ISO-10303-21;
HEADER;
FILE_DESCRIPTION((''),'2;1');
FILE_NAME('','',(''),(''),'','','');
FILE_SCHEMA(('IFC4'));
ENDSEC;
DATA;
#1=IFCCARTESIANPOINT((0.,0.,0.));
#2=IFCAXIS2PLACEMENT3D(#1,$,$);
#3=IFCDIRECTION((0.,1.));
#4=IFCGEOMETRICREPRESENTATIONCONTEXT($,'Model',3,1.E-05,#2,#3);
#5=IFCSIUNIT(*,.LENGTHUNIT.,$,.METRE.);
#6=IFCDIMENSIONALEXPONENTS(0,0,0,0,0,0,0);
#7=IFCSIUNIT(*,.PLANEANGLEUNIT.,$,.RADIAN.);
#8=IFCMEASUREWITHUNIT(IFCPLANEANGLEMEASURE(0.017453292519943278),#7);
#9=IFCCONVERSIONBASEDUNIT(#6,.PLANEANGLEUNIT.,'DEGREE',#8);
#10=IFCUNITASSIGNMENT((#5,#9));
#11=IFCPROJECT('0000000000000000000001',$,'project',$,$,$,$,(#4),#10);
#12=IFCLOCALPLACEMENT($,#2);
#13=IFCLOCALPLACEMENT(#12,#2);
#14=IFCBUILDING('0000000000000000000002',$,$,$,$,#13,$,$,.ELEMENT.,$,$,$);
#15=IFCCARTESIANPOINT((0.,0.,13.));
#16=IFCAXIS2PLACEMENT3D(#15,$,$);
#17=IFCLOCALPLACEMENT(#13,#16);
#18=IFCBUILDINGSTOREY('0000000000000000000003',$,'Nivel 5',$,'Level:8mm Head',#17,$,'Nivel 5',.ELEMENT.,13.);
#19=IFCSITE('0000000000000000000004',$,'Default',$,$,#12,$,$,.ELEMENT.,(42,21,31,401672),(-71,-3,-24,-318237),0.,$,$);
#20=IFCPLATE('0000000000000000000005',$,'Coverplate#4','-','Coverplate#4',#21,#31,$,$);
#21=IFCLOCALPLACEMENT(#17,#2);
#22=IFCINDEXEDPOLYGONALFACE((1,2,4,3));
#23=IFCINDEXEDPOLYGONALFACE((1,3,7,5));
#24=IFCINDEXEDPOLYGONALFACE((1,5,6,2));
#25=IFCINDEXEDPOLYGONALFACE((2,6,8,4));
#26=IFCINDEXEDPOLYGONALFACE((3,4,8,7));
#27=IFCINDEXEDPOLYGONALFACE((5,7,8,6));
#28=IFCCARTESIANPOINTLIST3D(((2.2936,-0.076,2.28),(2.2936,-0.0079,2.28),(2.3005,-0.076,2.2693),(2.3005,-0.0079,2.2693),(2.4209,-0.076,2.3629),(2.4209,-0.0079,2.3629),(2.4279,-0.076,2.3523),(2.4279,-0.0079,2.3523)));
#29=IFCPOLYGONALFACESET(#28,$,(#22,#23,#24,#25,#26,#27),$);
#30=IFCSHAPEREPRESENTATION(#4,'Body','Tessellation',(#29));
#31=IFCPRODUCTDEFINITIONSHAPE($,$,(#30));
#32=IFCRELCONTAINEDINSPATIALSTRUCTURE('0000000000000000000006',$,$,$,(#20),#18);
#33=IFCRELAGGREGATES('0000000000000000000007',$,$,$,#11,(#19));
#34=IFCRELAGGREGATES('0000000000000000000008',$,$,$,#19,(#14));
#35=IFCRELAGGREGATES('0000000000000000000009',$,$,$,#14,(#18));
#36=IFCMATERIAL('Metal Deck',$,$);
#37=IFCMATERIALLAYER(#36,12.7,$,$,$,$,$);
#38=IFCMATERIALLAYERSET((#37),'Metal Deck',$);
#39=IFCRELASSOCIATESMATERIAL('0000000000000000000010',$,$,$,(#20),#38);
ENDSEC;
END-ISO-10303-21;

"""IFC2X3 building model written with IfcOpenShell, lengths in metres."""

from ifc_helpers import new_model, entity, si_unit, converted_unit, direction, frame, origin, origin_with_axes, place, context, project, spatial, polyline, outline, extrude, material, layer, layer_set, element, save


model = new_model("IFC2X3")

# Units and contexts
model_context = context("Model", 3, precision=1e-05, world=origin(), true_north=direction((0.0, 1.0)))
ifc_project = project(units=[si_unit("LENGTHUNIT", "METRE"), converted_unit("PLANEANGLEUNIT", "DEGREE", entity("IfcPlaneAngleMeasure", 0.017453292519943278), si_unit("PLANEANGLEUNIT", "RADIAN"), dimensions=[0, 0, 0, 0, 0, 0, 0])], contexts=[model_context])

# Site, building, storey
site_placement = place(None, origin())
site = spatial("IfcSite", under=ifc_project, at=site_placement, Name="Default", CompositionType="ELEMENT", RefLatitude=(42, 21, 31, 401672), RefLongitude=(-71, -3, -24, -318237), RefElevation=0.0)
building_placement = place(site_placement, origin())
building = spatial("IfcBuilding", under=site, at=building_placement, CompositionType="ELEMENT")
storey_placement = place(building_placement, frame((0.0, 0.0, 13.0)))
storey = spatial("IfcBuildingStorey", under=building, at=storey_placement, Name="Nivel 5", ObjectType="Level:8mm Head", LongName="Nivel 5", CompositionType="ELEMENT", Elevation=13.0)

# Shared definitions
ifc_material_1 = material(Name="Metal Deck")
ifc_layer = layer(ifc_material_1, 12.7)
ifc_layer_set = layer_set([ifc_layer], Name="Metal Deck")

# Plate
plate_1_placement = place(storey_placement, frame((2.2936, -0.0079, 2.28), z_axis=(0.545876, 0.0, -0.837866), x_axis=(0.837866, 0.0, 0.545876)))
element("IfcPlate", 1, at=plate_1_placement, inside=storey, material=ifc_layer_set, Name="Coverplate#4", Description="-", ObjectType="Coverplate#4", context=model_context, shape_type="SweptSolid", body=[
    extrude(outline(polyline([(0.0, 0.0), (0.152, 0.0), (0.152, 0.0681), (0.0, 0.0681), (0.0, 0.0)])), origin_with_axes(), (0.0, 0.0, 1.0), 0.0127),
])

save(model, "model.ifc")
